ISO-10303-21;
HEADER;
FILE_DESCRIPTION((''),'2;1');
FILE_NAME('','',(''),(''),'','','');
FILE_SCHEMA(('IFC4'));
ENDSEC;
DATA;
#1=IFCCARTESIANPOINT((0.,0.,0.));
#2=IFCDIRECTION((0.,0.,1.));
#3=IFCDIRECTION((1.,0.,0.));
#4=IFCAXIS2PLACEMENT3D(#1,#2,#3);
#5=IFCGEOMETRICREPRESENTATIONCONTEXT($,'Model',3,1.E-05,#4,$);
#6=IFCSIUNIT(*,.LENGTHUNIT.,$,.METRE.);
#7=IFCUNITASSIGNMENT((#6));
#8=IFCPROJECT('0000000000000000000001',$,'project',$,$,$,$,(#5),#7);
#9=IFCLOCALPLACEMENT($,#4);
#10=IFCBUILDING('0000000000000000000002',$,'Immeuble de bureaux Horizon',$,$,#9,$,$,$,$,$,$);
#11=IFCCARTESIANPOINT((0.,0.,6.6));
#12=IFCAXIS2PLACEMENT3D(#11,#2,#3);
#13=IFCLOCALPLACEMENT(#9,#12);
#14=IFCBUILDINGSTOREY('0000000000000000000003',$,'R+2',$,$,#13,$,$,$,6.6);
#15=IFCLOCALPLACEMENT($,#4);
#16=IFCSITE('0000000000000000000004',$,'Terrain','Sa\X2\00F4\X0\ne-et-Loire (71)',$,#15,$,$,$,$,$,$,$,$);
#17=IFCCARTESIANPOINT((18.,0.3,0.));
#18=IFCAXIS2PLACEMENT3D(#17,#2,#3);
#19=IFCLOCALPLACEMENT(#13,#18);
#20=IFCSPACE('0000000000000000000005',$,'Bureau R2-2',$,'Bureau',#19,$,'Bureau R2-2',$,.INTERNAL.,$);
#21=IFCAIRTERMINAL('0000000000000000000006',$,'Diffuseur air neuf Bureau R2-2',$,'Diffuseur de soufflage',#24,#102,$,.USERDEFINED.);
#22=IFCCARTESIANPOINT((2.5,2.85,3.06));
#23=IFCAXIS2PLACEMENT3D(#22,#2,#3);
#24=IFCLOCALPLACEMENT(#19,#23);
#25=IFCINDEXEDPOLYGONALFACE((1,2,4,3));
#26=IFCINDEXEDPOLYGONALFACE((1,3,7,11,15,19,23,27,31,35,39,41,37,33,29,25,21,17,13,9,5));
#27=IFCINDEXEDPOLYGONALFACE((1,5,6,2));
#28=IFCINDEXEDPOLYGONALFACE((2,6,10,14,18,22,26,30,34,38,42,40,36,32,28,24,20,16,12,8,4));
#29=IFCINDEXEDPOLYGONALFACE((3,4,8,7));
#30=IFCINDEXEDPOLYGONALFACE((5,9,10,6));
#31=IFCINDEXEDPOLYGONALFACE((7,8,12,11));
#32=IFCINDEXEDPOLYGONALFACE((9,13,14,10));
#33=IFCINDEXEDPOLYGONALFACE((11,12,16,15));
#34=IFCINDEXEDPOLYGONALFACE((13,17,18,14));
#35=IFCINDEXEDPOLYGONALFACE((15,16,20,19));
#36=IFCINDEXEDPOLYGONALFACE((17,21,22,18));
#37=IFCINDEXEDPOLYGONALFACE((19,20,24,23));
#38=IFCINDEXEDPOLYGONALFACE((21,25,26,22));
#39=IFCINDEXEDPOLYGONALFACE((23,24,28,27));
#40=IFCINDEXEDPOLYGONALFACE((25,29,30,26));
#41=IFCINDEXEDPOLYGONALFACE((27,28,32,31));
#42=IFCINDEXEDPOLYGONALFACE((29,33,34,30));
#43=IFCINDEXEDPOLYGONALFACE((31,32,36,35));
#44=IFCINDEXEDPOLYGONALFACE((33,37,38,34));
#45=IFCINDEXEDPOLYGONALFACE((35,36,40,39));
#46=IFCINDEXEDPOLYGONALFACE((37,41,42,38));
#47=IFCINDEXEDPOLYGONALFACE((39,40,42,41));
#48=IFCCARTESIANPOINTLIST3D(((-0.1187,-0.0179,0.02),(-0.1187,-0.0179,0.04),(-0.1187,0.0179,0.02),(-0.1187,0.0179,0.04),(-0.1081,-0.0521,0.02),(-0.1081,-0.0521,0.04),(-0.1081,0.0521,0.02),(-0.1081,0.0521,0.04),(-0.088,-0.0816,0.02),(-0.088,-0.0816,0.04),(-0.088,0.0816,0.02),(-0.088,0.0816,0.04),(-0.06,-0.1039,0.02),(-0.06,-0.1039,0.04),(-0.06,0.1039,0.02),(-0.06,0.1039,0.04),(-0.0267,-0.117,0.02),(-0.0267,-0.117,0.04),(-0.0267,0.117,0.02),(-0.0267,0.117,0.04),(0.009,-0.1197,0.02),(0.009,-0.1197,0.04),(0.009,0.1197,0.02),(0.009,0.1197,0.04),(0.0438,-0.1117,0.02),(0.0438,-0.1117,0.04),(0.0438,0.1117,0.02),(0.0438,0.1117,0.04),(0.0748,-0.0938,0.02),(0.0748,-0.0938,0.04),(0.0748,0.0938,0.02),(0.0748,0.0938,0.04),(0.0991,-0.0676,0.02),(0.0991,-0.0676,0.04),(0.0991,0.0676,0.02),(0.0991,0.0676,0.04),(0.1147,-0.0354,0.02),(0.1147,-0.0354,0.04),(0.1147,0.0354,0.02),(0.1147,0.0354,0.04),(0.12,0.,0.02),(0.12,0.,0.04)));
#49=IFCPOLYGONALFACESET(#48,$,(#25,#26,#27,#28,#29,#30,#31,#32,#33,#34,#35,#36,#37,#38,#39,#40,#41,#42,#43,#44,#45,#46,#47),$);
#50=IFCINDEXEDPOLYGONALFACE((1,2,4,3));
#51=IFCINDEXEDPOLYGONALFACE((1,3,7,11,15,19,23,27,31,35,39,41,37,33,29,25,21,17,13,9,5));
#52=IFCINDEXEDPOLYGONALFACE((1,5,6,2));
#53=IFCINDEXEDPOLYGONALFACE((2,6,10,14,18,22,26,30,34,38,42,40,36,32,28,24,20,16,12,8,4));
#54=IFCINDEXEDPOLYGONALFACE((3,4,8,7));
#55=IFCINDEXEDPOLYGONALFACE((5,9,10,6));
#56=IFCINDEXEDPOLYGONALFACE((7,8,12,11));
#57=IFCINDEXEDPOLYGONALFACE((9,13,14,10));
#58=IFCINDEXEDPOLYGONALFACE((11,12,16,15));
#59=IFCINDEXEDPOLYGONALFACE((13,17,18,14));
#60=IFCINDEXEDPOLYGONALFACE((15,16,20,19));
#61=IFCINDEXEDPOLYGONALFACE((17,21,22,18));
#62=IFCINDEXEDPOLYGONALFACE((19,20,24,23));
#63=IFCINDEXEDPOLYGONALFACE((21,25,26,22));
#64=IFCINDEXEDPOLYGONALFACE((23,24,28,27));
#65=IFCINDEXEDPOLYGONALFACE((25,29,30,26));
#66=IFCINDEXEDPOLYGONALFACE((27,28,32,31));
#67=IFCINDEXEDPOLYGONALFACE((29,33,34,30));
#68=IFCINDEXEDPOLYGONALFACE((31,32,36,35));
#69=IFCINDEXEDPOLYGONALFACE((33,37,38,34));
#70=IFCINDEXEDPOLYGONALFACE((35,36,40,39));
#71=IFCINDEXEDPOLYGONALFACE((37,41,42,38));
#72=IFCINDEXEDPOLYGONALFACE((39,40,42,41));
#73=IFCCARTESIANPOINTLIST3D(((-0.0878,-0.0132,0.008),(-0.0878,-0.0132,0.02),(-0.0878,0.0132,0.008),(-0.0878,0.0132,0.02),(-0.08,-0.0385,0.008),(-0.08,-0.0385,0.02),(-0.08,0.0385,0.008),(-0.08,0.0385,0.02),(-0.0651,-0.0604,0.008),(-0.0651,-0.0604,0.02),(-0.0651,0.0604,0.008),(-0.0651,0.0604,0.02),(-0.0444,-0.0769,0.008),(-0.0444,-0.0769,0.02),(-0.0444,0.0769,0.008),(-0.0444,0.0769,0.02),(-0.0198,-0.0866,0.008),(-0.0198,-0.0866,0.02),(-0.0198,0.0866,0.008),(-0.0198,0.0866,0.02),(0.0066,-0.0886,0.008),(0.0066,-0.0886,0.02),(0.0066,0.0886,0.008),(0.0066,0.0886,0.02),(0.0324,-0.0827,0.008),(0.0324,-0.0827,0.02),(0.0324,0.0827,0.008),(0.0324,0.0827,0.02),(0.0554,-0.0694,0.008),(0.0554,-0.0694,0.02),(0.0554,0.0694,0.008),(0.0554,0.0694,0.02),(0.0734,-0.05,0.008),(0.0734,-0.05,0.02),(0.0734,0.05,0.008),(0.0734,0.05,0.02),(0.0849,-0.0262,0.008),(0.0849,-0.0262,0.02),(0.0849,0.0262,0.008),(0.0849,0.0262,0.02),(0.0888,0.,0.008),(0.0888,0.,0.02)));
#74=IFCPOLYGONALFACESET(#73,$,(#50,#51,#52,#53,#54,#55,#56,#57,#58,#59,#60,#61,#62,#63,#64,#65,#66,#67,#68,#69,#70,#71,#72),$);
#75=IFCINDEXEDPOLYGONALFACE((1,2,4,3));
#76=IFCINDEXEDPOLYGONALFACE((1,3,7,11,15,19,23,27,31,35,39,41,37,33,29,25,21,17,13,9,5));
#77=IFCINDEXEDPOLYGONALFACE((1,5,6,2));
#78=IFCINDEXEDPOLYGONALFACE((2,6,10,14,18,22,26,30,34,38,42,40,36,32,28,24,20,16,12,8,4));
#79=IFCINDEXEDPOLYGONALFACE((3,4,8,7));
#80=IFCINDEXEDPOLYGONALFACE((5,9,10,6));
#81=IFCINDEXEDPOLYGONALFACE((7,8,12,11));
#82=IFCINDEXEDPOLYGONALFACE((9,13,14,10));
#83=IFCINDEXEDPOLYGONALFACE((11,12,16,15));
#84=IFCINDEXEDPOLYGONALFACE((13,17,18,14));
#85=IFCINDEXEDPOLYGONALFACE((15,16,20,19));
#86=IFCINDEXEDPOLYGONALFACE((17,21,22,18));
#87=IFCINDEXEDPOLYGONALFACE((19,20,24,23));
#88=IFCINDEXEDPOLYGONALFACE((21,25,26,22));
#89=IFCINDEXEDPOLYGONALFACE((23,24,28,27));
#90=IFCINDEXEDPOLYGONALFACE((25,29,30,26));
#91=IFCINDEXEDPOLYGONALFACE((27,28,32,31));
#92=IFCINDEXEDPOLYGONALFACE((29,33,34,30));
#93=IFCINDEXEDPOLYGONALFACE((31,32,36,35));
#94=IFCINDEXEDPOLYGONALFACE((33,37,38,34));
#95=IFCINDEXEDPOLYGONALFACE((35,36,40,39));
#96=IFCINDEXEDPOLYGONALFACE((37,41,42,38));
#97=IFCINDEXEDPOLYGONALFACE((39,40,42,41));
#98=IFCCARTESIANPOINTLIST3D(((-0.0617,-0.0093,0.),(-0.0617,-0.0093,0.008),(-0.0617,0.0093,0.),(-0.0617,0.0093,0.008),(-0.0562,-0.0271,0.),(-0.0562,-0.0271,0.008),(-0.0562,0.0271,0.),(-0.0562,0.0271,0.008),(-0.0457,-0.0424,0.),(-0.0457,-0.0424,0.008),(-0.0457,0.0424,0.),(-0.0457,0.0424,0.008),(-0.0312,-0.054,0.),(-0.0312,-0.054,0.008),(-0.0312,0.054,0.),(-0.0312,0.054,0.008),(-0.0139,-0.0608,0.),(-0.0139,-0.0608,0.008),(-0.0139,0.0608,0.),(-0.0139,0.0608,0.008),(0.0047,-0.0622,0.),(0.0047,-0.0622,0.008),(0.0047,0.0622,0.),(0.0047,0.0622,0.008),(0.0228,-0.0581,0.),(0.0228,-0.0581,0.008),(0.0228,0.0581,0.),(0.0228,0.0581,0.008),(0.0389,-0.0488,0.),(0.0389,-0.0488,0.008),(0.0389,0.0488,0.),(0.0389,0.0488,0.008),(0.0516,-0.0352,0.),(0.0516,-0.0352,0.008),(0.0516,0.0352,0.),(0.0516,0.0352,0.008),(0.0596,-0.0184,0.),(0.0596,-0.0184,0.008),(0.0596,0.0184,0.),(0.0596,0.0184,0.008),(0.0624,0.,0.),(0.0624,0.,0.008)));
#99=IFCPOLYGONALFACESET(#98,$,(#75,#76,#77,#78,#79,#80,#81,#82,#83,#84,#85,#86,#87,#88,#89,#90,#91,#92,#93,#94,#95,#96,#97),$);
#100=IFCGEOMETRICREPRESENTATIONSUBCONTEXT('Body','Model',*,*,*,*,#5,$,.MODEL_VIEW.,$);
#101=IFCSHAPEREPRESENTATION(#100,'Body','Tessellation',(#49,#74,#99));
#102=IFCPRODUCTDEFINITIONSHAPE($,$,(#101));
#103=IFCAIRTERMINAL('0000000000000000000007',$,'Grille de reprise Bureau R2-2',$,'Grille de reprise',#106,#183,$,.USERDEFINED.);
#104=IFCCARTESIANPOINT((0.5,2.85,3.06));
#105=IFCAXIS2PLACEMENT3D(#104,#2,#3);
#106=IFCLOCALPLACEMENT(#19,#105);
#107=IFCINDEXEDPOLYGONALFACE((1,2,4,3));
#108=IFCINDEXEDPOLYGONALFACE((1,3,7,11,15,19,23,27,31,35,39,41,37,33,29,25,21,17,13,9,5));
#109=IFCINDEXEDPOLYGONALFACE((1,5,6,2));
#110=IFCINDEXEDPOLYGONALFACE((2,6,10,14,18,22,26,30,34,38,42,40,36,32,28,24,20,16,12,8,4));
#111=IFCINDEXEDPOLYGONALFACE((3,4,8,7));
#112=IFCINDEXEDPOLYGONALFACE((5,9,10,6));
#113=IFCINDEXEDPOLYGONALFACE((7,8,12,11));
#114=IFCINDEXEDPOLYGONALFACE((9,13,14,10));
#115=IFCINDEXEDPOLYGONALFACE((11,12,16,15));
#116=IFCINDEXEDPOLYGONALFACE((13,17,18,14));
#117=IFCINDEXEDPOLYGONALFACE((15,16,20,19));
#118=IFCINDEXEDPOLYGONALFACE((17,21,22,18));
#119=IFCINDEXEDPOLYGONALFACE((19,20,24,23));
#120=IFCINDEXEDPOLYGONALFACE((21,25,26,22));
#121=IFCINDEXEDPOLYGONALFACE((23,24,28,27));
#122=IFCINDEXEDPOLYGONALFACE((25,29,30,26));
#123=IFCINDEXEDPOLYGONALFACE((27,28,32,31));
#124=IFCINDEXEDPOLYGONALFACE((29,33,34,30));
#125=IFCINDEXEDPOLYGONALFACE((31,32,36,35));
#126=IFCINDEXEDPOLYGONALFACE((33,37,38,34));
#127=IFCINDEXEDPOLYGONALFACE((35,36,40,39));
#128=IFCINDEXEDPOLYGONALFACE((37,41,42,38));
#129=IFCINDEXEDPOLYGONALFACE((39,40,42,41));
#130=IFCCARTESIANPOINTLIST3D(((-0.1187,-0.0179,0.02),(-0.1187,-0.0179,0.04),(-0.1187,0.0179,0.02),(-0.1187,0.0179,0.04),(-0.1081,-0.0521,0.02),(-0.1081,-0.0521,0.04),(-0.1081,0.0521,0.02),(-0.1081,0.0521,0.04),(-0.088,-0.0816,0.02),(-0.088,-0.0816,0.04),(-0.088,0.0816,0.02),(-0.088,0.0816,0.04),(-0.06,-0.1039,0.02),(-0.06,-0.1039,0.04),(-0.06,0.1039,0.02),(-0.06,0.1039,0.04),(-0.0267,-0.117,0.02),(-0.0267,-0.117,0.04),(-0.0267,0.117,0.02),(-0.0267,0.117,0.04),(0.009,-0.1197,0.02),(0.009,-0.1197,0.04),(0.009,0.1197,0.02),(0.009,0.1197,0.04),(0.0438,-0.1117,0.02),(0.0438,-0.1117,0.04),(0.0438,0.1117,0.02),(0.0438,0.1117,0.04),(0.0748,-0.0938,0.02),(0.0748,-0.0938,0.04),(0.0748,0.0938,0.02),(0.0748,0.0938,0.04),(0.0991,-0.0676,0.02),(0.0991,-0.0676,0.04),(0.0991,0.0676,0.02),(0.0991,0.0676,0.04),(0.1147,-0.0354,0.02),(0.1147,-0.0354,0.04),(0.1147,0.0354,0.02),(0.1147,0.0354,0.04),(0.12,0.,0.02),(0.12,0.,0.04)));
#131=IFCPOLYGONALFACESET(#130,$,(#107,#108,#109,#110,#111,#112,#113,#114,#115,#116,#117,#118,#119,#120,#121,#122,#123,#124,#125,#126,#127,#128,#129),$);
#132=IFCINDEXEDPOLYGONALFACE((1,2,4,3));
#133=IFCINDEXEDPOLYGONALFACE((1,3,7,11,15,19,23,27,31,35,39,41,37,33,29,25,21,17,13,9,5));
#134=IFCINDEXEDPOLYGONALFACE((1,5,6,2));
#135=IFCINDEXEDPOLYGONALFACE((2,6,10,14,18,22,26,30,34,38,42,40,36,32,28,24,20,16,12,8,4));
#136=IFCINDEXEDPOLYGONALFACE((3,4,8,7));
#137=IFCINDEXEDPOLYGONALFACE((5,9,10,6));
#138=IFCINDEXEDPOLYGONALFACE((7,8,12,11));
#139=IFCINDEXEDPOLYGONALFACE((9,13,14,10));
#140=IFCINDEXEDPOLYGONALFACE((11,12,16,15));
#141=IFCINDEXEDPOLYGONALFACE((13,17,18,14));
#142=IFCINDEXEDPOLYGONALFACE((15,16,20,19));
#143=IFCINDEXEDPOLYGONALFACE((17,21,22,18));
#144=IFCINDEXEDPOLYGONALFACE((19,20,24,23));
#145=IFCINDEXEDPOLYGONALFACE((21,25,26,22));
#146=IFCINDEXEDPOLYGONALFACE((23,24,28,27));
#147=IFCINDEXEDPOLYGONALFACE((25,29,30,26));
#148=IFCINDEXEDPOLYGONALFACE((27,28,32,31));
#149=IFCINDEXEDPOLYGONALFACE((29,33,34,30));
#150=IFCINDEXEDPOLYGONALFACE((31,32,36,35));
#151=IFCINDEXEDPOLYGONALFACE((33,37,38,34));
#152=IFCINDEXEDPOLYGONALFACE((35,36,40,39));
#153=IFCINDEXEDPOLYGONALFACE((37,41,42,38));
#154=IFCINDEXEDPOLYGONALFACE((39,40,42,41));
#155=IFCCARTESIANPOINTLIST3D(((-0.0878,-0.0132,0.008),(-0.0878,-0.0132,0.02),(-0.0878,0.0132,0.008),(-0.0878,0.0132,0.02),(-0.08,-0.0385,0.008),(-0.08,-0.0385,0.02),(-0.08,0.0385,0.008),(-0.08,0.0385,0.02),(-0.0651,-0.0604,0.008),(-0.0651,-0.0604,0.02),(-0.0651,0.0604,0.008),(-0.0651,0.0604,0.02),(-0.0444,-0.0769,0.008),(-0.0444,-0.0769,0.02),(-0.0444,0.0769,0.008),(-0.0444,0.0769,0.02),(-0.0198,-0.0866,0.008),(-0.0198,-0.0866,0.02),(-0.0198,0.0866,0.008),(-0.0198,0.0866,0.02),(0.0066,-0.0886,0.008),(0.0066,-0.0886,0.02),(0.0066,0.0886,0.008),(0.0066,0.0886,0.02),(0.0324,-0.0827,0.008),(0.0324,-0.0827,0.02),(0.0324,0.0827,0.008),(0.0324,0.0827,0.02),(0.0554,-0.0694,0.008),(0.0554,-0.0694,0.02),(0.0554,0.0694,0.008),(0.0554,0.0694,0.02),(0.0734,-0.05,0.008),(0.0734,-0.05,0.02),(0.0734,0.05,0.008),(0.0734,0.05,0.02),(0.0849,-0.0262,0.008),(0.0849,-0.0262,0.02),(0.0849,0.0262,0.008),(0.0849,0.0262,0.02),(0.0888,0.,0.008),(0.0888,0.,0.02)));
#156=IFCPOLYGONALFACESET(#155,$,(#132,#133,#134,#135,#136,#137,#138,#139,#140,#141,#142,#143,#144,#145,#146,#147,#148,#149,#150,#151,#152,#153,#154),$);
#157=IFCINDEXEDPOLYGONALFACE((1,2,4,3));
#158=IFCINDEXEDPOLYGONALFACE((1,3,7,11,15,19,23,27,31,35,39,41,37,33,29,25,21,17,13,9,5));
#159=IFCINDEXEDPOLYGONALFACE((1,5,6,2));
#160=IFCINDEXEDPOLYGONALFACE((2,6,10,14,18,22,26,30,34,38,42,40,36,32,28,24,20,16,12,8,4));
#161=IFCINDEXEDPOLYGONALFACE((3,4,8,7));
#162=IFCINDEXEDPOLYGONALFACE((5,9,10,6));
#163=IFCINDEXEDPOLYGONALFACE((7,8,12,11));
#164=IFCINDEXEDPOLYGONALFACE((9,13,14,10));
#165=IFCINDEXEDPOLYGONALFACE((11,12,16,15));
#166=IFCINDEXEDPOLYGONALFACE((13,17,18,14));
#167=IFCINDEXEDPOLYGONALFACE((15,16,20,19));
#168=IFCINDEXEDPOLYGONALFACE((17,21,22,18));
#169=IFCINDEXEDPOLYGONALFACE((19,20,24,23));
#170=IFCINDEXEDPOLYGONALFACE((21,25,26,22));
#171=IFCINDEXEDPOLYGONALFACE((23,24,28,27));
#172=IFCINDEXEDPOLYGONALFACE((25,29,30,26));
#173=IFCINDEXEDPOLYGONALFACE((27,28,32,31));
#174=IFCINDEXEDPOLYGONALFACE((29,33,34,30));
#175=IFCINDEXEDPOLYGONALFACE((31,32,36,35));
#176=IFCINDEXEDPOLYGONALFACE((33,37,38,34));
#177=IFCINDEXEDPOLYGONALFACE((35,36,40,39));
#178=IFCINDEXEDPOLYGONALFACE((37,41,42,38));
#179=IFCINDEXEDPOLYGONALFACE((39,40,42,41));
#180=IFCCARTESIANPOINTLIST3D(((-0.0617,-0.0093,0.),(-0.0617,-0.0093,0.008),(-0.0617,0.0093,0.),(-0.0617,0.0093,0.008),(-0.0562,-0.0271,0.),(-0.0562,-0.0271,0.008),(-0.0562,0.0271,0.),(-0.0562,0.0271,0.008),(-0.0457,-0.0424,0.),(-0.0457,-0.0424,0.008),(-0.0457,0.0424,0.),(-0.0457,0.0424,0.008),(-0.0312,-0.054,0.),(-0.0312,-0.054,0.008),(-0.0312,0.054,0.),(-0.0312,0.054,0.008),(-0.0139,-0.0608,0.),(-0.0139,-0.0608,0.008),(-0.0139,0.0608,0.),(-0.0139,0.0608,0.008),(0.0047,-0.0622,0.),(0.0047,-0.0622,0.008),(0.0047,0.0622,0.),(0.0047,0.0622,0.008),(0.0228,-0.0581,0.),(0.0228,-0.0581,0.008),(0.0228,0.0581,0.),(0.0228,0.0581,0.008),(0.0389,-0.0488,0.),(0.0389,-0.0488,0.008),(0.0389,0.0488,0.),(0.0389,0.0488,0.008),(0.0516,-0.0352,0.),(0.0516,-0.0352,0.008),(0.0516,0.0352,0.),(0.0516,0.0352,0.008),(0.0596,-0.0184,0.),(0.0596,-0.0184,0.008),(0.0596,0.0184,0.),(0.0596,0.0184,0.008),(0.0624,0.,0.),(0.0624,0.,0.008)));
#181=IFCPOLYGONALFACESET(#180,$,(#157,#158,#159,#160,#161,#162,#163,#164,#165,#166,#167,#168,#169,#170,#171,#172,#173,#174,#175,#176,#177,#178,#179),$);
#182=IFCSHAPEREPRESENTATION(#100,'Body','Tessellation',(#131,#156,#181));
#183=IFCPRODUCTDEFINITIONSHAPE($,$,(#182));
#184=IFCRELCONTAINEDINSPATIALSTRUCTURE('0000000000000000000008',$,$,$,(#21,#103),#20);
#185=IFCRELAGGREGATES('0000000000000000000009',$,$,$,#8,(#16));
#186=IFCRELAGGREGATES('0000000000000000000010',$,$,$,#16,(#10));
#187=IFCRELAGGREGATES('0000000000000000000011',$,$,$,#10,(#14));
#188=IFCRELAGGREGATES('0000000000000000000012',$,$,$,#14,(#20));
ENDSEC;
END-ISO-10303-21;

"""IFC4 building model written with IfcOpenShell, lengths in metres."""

from ifc_helpers import new_model, si_unit, frame, origin_with_axes, place, context, subcontext, project, spatial, circle, extrude, element, save


model = new_model("IFC4")

# Units and contexts
model_context = context("Model", 3, precision=1e-05, world=origin_with_axes())
body_context = subcontext(model_context, "Body", "Model", "MODEL_VIEW")
ifc_project = project(units=[si_unit("LENGTHUNIT", "METRE")], contexts=[model_context])

# Site, building, storey
site_placement = place(None, origin_with_axes())
site = spatial("IfcSite", under=ifc_project, at=site_placement, Name="Terrain", Description="Saône-et-Loire (71)")
building_placement = place(None, origin_with_axes())
building = spatial("IfcBuilding", under=site, at=building_placement, Name="Immeuble de bureaux Horizon")
storey_placement = place(building_placement, frame((0.0, 0.0, 6.6), z_axis=(0.0, 0.0, 1.0), x_axis=(1.0, 0.0, 0.0)))
storey = spatial("IfcBuildingStorey", under=building, at=storey_placement, Name="R+2", Elevation=6.6)

# Shared definitions
space_1_placement = place(storey_placement, frame((18.0, 0.3, 0.0), z_axis=(0.0, 0.0, 1.0), x_axis=(1.0, 0.0, 0.0)))
space_1 = spatial("IfcSpace", under=storey, at=space_1_placement, Name="Bureau R2-2", ObjectType="Bureau", LongName="Bureau R2-2", PredefinedType="INTERNAL")

# Air terminal
air_terminal_1_placement = place(space_1_placement, frame((2.5, 2.85, 3.06), z_axis=(0.0, 0.0, 1.0), x_axis=(1.0, 0.0, 0.0)))
element("IfcAirTerminal", 1, at=air_terminal_1_placement, inside=space_1, Name="Diffuseur air neuf Bureau R2-2", ObjectType="Diffuseur de soufflage", PredefinedType="USERDEFINED", context=body_context, shape_type="SweptSolid", body=[
    extrude(circle(Radius=0.12), frame((0.0, 0.0, 0.02), z_axis=(0.0, 0.0, 1.0), x_axis=(1.0, 0.0, 0.0)), (0.0, 0.0, 1.0), 0.02),
    extrude(circle(Radius=0.0888), frame((0.0, 0.0, 0.008), z_axis=(0.0, 0.0, 1.0), x_axis=(1.0, 0.0, 0.0)), (0.0, 0.0, 1.0), 0.012),
    extrude(circle(Radius=0.0624), origin_with_axes(), (0.0, 0.0, 1.0), 0.008),
])

# Air terminal
air_terminal_2_placement = place(space_1_placement, frame((0.5, 2.85, 3.06), z_axis=(0.0, 0.0, 1.0), x_axis=(1.0, 0.0, 0.0)))
element("IfcAirTerminal", 2, at=air_terminal_2_placement, inside=space_1, Name="Grille de reprise Bureau R2-2", ObjectType="Grille de reprise", PredefinedType="USERDEFINED", context=body_context, shape_type="SweptSolid", body=[
    extrude(circle(Radius=0.12), frame((0.0, 0.0, 0.02), z_axis=(0.0, 0.0, 1.0), x_axis=(1.0, 0.0, 0.0)), (0.0, 0.0, 1.0), 0.02),
    extrude(circle(Radius=0.0888), frame((0.0, 0.0, 0.008), z_axis=(0.0, 0.0, 1.0), x_axis=(1.0, 0.0, 0.0)), (0.0, 0.0, 1.0), 0.012),
    extrude(circle(Radius=0.0624), origin_with_axes(), (0.0, 0.0, 1.0), 0.008),
])

save(model, "model.ifc")
